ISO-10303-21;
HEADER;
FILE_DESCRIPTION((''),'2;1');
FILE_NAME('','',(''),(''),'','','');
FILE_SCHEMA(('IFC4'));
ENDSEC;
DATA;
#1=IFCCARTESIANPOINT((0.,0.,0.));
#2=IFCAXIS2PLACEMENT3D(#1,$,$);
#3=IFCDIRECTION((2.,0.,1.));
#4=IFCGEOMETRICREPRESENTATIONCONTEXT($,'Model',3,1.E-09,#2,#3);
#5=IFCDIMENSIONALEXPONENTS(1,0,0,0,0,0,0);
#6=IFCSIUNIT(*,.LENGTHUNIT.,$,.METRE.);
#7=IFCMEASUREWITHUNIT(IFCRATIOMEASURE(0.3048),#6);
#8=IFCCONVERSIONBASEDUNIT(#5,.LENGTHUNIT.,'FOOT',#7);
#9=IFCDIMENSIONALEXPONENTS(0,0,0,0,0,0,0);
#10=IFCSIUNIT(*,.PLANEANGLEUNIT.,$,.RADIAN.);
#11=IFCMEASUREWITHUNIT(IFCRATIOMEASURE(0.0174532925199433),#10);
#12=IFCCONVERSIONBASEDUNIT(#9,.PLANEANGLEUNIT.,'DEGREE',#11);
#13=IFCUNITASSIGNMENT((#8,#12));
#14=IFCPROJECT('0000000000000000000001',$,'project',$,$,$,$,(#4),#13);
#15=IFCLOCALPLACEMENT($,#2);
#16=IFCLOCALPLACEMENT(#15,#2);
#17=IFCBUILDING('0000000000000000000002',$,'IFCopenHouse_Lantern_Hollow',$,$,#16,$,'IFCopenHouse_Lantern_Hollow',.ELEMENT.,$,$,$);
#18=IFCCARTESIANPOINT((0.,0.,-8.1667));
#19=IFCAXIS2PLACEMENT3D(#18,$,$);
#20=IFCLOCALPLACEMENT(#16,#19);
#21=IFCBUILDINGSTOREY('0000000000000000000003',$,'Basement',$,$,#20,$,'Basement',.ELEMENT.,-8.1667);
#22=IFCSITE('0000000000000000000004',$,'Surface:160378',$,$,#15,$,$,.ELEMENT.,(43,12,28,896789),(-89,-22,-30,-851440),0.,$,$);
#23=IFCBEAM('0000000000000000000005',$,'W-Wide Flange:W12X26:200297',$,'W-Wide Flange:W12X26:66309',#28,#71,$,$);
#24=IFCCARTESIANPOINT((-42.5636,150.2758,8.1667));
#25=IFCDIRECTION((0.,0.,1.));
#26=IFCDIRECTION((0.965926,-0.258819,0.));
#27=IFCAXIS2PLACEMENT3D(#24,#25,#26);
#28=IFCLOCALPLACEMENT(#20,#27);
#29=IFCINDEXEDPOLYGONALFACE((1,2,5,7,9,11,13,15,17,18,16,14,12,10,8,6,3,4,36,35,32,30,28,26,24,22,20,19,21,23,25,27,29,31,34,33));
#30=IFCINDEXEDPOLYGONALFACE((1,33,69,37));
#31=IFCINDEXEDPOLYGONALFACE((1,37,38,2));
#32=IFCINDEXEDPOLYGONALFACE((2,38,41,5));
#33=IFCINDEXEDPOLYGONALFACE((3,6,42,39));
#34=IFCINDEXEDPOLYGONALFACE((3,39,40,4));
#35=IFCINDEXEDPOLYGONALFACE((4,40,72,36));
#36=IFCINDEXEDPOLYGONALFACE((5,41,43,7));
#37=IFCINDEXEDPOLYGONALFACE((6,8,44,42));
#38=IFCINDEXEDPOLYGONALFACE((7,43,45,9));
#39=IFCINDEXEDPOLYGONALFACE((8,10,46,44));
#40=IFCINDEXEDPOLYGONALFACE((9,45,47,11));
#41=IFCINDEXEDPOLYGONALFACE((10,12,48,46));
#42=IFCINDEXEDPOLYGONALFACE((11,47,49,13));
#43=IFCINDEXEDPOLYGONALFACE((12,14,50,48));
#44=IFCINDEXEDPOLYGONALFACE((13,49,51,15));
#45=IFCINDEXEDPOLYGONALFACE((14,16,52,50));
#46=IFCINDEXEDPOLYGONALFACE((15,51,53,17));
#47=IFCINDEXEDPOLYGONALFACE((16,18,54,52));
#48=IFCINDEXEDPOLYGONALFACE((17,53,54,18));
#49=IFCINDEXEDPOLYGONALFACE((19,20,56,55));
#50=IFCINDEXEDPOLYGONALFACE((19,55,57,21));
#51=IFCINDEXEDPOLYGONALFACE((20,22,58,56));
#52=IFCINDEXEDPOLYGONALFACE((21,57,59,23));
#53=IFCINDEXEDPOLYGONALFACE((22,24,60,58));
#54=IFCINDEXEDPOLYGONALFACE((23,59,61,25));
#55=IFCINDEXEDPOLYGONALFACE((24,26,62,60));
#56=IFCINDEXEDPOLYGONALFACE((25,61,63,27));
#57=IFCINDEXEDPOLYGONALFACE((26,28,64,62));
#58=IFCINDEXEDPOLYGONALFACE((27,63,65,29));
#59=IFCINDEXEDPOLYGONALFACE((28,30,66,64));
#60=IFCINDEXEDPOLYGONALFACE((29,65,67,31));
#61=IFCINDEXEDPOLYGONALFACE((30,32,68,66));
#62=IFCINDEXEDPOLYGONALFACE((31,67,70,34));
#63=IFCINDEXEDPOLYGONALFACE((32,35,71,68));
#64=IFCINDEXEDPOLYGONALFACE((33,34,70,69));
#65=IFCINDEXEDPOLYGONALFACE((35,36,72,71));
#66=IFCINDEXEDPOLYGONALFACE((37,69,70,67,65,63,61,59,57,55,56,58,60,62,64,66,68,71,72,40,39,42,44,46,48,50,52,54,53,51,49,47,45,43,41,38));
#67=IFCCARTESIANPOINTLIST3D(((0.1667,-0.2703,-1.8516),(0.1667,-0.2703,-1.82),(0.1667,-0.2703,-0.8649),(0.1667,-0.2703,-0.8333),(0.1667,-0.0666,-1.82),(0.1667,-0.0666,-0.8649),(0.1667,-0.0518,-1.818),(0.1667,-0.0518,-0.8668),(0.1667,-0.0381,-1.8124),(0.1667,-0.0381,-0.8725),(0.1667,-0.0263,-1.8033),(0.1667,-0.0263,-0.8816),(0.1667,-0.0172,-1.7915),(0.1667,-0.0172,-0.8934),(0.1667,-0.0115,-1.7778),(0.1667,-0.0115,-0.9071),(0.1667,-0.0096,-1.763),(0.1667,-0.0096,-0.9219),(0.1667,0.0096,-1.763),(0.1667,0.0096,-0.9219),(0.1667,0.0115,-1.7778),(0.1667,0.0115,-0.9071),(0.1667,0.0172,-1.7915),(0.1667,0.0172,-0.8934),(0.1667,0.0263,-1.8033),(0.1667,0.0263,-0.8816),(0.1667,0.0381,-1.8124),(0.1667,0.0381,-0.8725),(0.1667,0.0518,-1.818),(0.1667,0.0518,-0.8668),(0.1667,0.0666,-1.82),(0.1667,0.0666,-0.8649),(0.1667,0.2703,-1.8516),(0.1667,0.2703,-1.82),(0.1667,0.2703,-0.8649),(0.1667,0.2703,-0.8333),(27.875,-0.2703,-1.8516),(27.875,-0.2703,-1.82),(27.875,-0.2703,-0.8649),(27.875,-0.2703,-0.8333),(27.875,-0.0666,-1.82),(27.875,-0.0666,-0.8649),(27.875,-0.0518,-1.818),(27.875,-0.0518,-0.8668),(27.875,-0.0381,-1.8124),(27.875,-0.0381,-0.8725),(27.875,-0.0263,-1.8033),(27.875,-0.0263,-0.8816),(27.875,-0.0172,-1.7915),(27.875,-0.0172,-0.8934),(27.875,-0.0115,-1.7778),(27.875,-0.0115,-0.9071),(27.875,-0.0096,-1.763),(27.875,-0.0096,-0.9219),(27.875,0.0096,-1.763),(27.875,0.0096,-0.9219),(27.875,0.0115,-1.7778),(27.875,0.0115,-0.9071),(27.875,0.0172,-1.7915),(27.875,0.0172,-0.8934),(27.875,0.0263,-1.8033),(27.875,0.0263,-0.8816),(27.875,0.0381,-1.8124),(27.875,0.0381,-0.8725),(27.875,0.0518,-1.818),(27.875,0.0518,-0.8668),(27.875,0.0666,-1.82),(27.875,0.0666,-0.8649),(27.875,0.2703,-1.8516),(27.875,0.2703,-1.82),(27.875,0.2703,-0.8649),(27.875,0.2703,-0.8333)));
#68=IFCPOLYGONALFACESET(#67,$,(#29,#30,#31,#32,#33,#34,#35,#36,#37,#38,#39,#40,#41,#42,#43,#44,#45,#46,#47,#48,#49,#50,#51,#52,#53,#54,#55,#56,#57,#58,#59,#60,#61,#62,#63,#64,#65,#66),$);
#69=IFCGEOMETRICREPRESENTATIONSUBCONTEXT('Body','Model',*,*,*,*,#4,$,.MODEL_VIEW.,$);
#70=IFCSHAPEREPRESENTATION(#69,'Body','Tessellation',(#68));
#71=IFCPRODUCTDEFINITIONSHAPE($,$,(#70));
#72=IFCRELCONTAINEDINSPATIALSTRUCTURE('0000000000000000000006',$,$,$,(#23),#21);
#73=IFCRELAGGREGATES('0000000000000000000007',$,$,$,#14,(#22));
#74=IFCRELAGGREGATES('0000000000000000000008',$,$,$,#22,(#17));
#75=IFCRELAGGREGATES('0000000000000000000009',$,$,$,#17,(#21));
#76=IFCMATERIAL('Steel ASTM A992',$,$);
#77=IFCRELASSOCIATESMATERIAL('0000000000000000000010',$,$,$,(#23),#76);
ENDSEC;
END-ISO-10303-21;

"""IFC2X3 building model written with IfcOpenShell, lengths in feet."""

from ifc_helpers import new_model, entity, si_unit, converted_unit, direction, frame, frame_2d, origin, place, context, subcontext, project, spatial, i_section, extrude, material, element, save


model = new_model("IFC2X3")

# Units and contexts
model_context = context("Model", 3, precision=1e-09, world=origin(), true_north=direction((2.0, 0.0, 1.0)))
body_context = subcontext(model_context, "Body", "Model", "MODEL_VIEW")
ifc_project = project(units=[converted_unit("LENGTHUNIT", "FOOT", entity("IfcRatioMeasure", 0.3048), si_unit("LENGTHUNIT", "METRE"), dimensions=[1, 0, 0, 0, 0, 0, 0]), converted_unit("PLANEANGLEUNIT", "DEGREE", entity("IfcRatioMeasure", 0.0174532925199433), si_unit("PLANEANGLEUNIT", "RADIAN"), dimensions=[0, 0, 0, 0, 0, 0, 0])], contexts=[model_context])

# Site, building, storey
site_placement = place(None, origin())
site = spatial("IfcSite", under=ifc_project, at=site_placement, Name="Surface:160378", CompositionType="ELEMENT", RefLatitude=(43, 12, 28, 896789), RefLongitude=(-89, -22, -30, -851440), RefElevation=0.0)
building_placement = place(site_placement, origin())
building = spatial("IfcBuilding", under=site, at=building_placement, Name="IFCopenHouse_Lantern_Hollow", LongName="IFCopenHouse_Lantern_Hollow", CompositionType="ELEMENT")
storey_placement = place(building_placement, frame((0.0, 0.0, -8.1667)))
storey = spatial("IfcBuildingStorey", under=building, at=storey_placement, Name="Basement", LongName="Basement", CompositionType="ELEMENT", Elevation=-8.1667)

# Beam
ifc_material_1 = material(Name="Steel ASTM A992")
beam_placement = place(storey_placement, frame((-42.5636, 150.2758, 8.1667), z_axis=(0.0, 0.0, 1.0), x_axis=(0.965926, -0.258819, 0.0)))
element("IfcBeam", 1, at=beam_placement, inside=storey, material=ifc_material_1, Name="W-Wide Flange:W12X26:200297", ObjectType="W-Wide Flange:W12X26:66309", context=body_context, shape_type="SweptSolid", body=[
    extrude(i_section(OverallWidth=0.5407, OverallDepth=1.0182, WebThickness=0.0192, FlangeThickness=0.0316, FilletRadius=0.057, at=frame_2d((0.0, 0.0), x_axis=(0.0, 1.0))), frame((0.1667, 0.0, -1.3424), z_axis=(1.0, 0.0, 0.0), x_axis=(0.0, 0.0, -1.0)), (0.0, 0.0, 1.0), 27.7083),
])

save(model, "model.ifc")
